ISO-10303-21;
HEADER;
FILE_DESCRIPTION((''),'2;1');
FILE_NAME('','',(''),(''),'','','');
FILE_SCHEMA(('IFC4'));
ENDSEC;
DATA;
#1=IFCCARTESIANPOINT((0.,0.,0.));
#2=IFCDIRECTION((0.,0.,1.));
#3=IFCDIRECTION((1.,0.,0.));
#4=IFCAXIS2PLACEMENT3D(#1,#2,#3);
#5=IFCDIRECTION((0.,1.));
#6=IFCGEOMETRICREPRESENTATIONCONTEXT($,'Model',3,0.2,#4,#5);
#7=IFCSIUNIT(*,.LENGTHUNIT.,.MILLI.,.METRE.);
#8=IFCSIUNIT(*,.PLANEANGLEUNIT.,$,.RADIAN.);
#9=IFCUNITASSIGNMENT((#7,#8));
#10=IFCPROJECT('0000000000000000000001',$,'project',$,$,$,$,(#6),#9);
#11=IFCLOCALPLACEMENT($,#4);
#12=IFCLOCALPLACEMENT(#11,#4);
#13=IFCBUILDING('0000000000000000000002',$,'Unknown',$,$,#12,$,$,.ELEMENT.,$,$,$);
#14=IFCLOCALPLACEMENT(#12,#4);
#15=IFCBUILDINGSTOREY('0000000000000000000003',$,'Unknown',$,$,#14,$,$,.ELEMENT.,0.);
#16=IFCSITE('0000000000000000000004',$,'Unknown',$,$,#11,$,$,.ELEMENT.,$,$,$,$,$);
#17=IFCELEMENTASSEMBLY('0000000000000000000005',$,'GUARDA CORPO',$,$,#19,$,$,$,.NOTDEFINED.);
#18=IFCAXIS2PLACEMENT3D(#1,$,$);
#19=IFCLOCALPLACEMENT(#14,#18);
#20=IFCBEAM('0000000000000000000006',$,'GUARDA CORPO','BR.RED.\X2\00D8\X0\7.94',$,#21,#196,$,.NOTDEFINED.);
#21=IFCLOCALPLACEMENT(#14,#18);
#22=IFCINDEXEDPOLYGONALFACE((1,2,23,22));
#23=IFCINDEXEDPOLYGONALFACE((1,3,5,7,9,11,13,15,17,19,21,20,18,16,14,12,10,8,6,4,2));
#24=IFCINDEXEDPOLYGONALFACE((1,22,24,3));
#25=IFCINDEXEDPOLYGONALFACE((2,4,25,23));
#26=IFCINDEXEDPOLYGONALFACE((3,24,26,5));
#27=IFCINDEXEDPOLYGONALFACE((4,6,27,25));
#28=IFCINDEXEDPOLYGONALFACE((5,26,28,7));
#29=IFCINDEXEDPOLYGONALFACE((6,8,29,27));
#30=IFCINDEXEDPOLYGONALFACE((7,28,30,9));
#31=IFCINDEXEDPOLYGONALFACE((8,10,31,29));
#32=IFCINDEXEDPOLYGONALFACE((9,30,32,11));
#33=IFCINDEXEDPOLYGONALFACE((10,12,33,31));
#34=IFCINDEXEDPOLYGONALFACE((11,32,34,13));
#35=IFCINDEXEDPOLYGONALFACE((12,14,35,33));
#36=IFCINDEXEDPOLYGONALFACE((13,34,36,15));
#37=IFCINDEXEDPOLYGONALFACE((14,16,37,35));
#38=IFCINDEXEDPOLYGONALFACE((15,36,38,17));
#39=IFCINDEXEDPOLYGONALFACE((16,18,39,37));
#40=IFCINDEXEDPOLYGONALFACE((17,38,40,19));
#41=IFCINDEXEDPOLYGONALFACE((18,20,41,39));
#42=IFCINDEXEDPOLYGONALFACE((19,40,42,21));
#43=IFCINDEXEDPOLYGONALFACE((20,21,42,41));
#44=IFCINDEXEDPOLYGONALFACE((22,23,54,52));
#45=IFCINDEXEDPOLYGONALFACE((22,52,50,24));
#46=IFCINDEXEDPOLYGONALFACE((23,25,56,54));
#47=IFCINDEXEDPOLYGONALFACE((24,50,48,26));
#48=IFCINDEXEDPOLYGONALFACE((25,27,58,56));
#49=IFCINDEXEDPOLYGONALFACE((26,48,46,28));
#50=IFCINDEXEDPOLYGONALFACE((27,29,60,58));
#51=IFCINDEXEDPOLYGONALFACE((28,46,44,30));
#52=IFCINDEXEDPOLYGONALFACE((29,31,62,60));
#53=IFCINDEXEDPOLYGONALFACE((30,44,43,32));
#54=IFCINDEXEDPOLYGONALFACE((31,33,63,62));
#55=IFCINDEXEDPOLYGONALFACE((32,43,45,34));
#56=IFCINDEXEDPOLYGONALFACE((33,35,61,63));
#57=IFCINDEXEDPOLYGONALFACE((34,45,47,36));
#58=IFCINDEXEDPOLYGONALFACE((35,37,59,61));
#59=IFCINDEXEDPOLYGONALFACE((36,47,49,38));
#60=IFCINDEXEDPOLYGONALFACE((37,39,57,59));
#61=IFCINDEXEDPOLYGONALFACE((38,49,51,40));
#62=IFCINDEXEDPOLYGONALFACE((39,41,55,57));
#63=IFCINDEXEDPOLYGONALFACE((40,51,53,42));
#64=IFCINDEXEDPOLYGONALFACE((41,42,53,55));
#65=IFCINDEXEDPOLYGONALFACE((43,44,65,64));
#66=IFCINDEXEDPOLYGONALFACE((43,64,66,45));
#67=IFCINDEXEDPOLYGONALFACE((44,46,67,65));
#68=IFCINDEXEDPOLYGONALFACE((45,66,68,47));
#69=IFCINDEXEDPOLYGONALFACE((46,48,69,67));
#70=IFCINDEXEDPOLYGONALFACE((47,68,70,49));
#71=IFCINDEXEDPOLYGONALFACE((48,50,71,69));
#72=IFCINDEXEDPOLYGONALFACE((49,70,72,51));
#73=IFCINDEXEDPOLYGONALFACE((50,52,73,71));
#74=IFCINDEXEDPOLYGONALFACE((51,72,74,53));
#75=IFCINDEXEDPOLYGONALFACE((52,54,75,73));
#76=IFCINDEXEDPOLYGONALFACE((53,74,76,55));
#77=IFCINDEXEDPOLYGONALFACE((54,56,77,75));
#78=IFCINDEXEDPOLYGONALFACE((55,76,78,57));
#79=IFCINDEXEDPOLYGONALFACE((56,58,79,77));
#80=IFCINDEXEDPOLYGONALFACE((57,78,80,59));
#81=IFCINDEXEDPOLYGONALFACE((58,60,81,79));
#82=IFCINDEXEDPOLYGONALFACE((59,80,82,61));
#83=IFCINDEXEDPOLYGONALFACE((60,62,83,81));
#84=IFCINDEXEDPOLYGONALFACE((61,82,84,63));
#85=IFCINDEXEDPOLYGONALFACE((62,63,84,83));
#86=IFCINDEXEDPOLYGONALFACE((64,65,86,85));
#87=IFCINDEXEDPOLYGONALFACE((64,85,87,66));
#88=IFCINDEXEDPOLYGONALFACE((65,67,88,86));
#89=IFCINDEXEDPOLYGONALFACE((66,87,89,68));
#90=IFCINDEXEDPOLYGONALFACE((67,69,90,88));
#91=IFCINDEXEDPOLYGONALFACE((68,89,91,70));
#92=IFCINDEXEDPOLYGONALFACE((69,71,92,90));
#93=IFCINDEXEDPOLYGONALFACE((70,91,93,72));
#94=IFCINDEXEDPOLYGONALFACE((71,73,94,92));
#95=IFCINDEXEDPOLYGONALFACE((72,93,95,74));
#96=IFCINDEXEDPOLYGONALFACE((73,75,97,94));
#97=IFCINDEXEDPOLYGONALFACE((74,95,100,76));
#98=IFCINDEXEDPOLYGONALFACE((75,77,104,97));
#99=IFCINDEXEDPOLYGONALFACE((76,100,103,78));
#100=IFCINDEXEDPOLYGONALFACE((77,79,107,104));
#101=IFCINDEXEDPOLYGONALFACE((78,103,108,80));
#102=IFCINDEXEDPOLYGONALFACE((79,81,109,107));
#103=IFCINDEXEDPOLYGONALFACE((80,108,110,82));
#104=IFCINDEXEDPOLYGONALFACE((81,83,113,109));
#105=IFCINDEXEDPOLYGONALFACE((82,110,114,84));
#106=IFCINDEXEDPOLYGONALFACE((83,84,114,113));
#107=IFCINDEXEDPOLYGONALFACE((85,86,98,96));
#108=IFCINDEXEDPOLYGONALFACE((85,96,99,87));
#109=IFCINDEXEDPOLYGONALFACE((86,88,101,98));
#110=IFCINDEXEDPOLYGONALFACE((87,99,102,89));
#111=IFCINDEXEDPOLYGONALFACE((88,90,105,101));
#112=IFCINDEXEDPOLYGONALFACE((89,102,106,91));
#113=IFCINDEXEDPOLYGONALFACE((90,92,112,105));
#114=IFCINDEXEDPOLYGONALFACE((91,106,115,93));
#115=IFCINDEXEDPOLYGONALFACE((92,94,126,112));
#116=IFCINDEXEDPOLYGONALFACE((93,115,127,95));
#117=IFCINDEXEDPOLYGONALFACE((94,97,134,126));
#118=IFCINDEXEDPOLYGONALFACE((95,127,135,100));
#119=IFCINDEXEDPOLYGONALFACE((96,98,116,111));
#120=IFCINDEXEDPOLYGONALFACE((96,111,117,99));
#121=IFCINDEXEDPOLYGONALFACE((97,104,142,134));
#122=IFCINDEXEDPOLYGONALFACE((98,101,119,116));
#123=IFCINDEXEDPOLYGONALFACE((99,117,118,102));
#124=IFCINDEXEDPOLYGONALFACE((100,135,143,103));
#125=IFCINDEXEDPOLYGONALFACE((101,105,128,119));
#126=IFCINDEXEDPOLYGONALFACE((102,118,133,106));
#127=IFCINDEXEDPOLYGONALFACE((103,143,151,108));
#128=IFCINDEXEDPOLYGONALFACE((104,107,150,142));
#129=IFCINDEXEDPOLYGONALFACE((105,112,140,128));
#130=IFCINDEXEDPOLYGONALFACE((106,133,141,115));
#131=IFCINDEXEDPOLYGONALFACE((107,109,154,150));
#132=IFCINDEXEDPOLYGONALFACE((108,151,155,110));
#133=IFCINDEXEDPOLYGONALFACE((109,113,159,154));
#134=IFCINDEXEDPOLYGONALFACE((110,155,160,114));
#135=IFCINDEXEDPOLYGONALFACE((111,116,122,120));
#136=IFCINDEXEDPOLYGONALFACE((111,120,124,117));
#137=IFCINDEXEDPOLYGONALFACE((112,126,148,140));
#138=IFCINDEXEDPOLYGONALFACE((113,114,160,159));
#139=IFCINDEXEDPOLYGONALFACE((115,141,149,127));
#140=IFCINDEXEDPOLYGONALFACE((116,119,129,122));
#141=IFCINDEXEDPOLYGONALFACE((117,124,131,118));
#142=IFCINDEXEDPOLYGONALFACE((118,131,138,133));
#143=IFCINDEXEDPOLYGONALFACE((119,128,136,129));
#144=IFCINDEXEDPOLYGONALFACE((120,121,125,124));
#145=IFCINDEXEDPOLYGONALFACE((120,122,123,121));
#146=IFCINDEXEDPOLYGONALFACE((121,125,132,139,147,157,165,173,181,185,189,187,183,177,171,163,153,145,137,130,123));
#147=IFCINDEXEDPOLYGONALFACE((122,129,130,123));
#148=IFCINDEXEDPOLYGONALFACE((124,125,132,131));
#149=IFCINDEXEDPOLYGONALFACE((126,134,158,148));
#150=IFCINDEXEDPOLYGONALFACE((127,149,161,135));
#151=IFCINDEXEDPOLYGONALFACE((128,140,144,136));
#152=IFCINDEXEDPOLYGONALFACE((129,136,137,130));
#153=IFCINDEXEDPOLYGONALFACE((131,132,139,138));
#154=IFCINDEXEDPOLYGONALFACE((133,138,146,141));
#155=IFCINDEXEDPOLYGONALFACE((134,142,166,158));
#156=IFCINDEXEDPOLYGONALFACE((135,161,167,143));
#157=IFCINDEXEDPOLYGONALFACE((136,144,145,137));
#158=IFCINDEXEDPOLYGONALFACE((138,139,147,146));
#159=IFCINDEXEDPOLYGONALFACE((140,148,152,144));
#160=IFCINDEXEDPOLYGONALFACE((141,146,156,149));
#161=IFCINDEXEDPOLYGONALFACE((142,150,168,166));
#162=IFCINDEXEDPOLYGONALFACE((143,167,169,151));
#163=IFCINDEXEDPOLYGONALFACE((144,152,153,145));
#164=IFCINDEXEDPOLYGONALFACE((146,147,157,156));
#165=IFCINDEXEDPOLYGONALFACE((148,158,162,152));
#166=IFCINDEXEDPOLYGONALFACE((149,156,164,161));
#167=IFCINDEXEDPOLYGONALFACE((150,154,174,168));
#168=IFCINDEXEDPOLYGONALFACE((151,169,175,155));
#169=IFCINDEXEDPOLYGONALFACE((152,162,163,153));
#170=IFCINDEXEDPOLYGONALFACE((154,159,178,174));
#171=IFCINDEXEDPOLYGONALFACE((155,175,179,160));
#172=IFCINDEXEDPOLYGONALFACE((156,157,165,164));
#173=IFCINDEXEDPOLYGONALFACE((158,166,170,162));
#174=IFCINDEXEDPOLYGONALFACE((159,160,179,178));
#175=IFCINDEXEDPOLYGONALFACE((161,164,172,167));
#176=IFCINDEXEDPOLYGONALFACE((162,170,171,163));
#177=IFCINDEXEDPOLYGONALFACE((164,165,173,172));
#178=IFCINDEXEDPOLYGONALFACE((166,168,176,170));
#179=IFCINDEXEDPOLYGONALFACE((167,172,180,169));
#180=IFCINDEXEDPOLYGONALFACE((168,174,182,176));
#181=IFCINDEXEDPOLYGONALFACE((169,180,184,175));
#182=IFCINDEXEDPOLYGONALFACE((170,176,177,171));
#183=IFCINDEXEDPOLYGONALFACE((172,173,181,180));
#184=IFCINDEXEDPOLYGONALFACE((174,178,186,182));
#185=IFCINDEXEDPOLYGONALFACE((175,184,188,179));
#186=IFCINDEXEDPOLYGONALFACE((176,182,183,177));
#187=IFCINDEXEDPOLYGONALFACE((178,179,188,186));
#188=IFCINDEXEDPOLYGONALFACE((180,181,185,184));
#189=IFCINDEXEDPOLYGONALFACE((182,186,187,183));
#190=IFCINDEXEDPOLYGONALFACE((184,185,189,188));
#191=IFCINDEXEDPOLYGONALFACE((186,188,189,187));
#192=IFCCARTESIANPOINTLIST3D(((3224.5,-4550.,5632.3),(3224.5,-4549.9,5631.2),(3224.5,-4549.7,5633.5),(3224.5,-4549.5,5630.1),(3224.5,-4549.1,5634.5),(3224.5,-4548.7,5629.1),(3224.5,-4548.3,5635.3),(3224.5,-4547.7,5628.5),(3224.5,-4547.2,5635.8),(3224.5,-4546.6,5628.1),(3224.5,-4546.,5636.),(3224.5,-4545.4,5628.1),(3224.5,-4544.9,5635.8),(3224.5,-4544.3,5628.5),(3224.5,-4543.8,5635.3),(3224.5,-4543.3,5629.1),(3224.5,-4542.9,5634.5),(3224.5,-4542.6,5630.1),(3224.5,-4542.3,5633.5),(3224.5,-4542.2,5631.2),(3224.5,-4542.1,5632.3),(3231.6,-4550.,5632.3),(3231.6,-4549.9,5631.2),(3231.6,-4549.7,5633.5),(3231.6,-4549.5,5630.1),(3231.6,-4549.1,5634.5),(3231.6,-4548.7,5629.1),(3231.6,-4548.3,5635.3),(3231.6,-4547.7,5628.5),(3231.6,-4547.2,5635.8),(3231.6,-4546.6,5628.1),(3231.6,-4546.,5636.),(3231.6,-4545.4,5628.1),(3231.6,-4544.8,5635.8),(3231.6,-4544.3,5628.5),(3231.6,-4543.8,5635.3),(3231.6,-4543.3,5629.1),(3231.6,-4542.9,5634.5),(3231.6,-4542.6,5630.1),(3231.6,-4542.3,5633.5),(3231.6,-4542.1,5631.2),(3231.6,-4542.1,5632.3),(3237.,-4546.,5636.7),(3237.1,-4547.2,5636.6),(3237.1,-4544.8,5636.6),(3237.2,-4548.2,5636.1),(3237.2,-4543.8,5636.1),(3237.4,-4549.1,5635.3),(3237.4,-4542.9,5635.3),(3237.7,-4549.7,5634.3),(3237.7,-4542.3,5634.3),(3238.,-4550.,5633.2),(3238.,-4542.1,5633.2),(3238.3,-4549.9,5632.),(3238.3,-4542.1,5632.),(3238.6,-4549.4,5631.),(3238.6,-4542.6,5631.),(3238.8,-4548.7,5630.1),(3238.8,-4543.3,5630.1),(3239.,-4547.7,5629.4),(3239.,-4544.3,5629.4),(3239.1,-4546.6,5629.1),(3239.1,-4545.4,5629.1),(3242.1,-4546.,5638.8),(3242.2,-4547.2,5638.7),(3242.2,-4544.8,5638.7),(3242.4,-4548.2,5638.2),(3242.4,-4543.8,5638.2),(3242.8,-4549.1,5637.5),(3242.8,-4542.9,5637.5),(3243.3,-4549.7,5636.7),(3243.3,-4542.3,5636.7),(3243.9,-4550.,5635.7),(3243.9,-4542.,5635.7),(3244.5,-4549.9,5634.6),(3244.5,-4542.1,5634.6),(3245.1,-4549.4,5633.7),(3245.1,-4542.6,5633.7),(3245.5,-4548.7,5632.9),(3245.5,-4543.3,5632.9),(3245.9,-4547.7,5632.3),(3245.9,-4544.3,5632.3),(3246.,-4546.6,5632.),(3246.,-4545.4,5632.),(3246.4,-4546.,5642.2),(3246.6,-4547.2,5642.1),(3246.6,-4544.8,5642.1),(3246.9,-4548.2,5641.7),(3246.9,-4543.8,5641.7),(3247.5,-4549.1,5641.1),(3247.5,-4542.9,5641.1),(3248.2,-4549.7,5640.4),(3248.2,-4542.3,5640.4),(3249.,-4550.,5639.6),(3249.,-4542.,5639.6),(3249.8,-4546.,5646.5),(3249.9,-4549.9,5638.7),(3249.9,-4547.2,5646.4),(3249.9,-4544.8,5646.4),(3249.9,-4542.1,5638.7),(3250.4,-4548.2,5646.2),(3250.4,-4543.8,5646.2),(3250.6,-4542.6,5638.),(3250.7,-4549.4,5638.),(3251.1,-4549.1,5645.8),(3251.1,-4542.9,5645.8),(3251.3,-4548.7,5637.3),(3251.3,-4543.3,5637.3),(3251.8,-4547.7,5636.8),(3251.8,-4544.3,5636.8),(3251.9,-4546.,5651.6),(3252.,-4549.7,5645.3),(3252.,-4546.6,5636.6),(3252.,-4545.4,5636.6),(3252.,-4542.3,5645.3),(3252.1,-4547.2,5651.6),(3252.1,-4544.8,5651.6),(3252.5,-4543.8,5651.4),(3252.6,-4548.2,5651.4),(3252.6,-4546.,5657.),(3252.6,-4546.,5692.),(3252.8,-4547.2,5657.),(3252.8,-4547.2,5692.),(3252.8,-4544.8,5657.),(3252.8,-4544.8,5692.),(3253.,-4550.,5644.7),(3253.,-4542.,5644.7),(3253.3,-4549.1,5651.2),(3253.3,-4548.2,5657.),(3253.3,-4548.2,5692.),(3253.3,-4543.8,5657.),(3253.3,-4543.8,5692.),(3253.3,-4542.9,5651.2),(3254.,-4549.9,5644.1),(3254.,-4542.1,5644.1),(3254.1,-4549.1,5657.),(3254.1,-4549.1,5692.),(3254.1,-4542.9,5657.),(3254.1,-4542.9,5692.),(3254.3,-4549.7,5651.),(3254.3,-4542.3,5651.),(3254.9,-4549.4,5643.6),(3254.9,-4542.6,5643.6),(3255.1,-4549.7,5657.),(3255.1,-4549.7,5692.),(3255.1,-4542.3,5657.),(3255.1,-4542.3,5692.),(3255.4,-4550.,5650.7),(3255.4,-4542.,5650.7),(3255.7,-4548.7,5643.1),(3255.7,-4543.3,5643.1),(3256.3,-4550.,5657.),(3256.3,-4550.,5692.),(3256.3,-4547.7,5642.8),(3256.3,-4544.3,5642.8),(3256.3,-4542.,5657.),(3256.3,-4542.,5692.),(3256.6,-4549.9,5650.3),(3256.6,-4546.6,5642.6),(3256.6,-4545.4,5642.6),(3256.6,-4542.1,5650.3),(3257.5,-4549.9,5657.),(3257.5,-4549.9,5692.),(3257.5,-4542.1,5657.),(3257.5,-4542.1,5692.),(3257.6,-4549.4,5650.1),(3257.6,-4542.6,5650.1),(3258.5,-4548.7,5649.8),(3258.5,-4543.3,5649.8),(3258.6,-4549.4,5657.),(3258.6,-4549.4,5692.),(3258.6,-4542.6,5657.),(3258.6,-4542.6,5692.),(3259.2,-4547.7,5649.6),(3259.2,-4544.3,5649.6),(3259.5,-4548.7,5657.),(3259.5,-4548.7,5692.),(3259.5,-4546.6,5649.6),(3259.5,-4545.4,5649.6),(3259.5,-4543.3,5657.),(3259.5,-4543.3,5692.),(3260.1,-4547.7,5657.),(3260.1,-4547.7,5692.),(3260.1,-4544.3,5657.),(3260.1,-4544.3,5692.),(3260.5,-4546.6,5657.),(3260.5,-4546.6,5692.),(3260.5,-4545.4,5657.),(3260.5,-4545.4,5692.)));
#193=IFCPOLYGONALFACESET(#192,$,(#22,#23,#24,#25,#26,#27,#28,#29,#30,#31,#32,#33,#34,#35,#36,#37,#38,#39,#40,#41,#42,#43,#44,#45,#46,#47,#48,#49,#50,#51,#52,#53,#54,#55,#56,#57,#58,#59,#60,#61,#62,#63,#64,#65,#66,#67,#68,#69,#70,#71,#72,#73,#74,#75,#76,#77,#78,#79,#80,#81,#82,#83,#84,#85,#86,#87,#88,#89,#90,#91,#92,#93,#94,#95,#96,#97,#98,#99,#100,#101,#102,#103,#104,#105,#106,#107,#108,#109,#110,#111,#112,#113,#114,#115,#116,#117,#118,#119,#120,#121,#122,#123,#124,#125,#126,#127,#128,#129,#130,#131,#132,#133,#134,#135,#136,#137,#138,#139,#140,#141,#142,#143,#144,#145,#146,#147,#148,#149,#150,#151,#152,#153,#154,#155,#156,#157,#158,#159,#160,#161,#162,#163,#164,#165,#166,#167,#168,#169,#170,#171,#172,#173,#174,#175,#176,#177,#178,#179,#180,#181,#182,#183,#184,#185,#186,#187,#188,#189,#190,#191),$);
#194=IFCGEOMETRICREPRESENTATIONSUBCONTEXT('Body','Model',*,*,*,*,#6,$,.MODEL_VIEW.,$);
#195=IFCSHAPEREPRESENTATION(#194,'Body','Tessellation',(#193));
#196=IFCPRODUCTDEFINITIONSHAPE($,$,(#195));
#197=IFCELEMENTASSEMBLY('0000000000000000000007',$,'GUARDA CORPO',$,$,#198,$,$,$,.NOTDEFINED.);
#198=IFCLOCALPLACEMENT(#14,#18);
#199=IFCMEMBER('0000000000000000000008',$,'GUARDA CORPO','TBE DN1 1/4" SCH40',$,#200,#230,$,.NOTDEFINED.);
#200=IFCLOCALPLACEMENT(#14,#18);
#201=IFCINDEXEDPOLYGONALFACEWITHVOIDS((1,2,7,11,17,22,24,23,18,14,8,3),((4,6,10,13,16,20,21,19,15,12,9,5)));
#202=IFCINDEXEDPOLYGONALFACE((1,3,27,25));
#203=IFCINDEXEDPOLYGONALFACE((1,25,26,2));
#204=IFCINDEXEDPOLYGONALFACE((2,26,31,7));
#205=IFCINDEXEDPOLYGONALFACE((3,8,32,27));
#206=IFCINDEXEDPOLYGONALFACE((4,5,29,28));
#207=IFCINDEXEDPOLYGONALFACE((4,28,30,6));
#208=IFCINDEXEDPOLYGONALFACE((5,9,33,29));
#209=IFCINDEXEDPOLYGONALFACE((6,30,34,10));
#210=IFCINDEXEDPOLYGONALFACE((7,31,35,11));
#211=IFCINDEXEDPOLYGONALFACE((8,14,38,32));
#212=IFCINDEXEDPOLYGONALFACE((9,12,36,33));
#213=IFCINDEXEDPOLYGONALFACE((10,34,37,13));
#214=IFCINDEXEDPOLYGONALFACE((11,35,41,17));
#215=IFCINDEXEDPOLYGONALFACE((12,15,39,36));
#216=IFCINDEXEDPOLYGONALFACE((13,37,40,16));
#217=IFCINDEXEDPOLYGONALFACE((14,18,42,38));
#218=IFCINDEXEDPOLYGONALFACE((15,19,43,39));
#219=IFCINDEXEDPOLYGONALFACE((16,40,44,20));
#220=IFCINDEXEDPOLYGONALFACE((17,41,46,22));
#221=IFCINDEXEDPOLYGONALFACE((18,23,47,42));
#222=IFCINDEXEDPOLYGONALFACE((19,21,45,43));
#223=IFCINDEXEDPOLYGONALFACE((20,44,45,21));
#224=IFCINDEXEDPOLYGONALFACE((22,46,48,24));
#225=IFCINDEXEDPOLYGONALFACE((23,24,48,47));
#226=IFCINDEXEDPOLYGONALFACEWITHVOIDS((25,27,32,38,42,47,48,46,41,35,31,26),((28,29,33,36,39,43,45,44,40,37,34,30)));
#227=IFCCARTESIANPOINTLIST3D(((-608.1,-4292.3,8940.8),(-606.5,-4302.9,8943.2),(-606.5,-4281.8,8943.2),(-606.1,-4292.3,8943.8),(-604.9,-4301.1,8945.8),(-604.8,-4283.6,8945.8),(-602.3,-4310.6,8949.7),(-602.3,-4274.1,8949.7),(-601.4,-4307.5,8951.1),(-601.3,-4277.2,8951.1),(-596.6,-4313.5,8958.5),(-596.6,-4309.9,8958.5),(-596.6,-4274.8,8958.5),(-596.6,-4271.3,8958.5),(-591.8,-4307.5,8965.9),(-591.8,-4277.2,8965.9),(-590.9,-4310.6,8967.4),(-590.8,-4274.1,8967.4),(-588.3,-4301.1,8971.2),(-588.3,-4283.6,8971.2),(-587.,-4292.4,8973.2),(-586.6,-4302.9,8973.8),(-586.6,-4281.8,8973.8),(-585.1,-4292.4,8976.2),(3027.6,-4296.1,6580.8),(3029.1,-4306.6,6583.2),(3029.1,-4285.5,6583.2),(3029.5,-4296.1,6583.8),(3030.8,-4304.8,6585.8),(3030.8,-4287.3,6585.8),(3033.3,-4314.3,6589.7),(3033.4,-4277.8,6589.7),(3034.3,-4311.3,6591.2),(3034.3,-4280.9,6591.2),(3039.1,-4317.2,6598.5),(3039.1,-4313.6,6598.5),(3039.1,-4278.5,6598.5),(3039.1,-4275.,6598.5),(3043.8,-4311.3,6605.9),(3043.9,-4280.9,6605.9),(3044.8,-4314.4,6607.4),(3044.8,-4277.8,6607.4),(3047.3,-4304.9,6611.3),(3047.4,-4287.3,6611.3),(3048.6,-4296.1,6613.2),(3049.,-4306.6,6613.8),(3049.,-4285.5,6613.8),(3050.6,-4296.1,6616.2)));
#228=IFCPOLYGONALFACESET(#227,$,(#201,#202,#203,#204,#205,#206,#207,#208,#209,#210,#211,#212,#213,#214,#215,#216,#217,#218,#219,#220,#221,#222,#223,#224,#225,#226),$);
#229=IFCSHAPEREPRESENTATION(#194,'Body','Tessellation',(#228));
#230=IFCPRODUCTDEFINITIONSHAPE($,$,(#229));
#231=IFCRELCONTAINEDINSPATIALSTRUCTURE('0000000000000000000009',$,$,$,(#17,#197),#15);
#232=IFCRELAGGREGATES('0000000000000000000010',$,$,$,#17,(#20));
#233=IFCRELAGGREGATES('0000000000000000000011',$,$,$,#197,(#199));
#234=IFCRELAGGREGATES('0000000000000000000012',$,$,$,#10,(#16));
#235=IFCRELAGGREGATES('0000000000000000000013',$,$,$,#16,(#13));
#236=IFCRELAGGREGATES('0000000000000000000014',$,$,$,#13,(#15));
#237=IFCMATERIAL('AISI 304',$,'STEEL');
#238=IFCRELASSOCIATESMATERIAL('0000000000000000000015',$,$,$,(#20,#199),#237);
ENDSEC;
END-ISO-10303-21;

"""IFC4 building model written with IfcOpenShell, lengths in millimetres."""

from ifc_helpers import new_model, entity, si_unit, direction, frame, origin_with_axes, place, context, subcontext, project, spatial, line, indexed_curve, outline, extrude, material, element, aggregate, save


model = new_model("IFC4")

# Units and contexts
model_context = context("Model", 3, precision=0.2, world=origin_with_axes(), true_north=direction((0.0, 1.0)))
body_context = subcontext(model_context, "Body", "Model", "MODEL_VIEW")
ifc_project = project(units=[si_unit("LENGTHUNIT", "METRE", prefix="MILLI"), si_unit("PLANEANGLEUNIT", "RADIAN")], contexts=[model_context])

# Site, building, storey
site_placement = place(None, origin_with_axes())
site = spatial("IfcSite", under=ifc_project, at=site_placement, Name="Unknown", CompositionType="ELEMENT")
building_placement = place(site_placement, origin_with_axes())
building = spatial("IfcBuilding", under=site, at=building_placement, Name="Unknown", CompositionType="ELEMENT")
storey_placement = place(building_placement, origin_with_axes())
storey = spatial("IfcBuildingStorey", under=building, at=storey_placement, Name="Unknown", CompositionType="ELEMENT", Elevation=0.0)

# Element assembly, beam
assembly_1_placement = place(storey_placement, frame((2908.2, -5645.6, 3955.0), z_axis=(0.000512, -1.0, -0.000003), x_axis=(0.000003, -0.000003, 1.0)))
assembly_1 = element("IfcElementAssembly", 1, at=assembly_1_placement, inside=storey, Name="GUARDA CORPO", PredefinedType="NOTDEFINED")
ifc_material_1 = material(Name="AISI 304", Category="STEEL")
beam_1_placement = place(assembly_1_placement, frame((1737.0, -349.0, -1099.4), z_axis=(-0.000003, 1.0, 0.000512), x_axis=(-1.0, -0.000003, 0.0)))
beam_1 = element("IfcBeam", 2, at=beam_1_placement, material=ifc_material_1, Name="GUARDA CORPO", Description="BR.RED.Ø7.94", PredefinedType="NOTDEFINED", context=body_context, shape_type="SolidModel", body=[
    entity("IfcSweptDiskSolid", entity("IfcIndexedPolyCurve", entity("IfcCartesianPointList3D", [[0.0, 0.0, 0.0], [35.0, 0.0, 0.0], [52.7, 0.0, 7.3], [60.0, 0.0, 25.0], [60.0, 0.0, 32.1]]), [entity("IfcLineIndex", [1, 2]), entity("IfcArcIndex", [2, 3, 4]), entity("IfcLineIndex", [4, 5])]), 4.0),
])

# Element assembly, member
assembly_2_placement = place(storey_placement, frame((516.1, -4294.6, 7195.0), z_axis=(0.000512, 1.0, -0.000003), x_axis=(-0.000003, 0.000003, 1.0)))
assembly_2 = element("IfcElementAssembly", 3, at=assembly_2_placement, inside=storey, Name="GUARDA CORPO", PredefinedType="NOTDEFINED")
member_placement = place(assembly_2_placement, frame((-596.5, 2522.9, -0.2), z_axis=(0.838778, 0.544474, -0.000277), x_axis=(0.544474, -0.838778, 0.000428)))
member = element("IfcMember", 4, at=member_placement, material=ifc_material_1, Name="GUARDA CORPO", Description="TBE DN1 1/4\" SCH40", PredefinedType="NOTDEFINED", context=body_context, shape_type="SolidModel", body=[
    extrude(outline(indexed_curve([(21.1, 0.0), (18.3, 10.6), (10.6, 18.3), (0.0, 21.1), (-10.6, 18.3), (-18.3, 10.6), (-21.1, 0.0), (-18.3, -10.6), (-10.6, -18.3), (0.0, -21.1), (10.6, -18.3), (18.3, -10.6)], segments=[line(1, 2, 3, 4, 5, 6, 7, 8, 9, 10, 11, 12, 1)]), holes=[indexed_curve([(17.5, 0.0), (15.2, -8.8), (8.8, -15.2), (0.0, -17.5), (-8.8, -15.2), (-15.2, -8.8), (-17.5, 0.0), (-15.2, 8.8), (-8.8, 15.2), (0.0, 17.5), (8.8, 15.2), (15.2, 8.8)], segments=[line(1, 2, 3, 4, 5, 6, 7, 8, 9, 10, 11, 12, 1)])]), frame((0.0, 0.0, 0.0), z_axis=(-1.0, 0.0, 0.0), x_axis=(0.0, 0.0, 1.0)), (0.0, 0.0, -1.0), 4334.5),
])

aggregate(assembly_1, [beam_1])
aggregate(assembly_2, [member])

save(model, "model.ifc")
